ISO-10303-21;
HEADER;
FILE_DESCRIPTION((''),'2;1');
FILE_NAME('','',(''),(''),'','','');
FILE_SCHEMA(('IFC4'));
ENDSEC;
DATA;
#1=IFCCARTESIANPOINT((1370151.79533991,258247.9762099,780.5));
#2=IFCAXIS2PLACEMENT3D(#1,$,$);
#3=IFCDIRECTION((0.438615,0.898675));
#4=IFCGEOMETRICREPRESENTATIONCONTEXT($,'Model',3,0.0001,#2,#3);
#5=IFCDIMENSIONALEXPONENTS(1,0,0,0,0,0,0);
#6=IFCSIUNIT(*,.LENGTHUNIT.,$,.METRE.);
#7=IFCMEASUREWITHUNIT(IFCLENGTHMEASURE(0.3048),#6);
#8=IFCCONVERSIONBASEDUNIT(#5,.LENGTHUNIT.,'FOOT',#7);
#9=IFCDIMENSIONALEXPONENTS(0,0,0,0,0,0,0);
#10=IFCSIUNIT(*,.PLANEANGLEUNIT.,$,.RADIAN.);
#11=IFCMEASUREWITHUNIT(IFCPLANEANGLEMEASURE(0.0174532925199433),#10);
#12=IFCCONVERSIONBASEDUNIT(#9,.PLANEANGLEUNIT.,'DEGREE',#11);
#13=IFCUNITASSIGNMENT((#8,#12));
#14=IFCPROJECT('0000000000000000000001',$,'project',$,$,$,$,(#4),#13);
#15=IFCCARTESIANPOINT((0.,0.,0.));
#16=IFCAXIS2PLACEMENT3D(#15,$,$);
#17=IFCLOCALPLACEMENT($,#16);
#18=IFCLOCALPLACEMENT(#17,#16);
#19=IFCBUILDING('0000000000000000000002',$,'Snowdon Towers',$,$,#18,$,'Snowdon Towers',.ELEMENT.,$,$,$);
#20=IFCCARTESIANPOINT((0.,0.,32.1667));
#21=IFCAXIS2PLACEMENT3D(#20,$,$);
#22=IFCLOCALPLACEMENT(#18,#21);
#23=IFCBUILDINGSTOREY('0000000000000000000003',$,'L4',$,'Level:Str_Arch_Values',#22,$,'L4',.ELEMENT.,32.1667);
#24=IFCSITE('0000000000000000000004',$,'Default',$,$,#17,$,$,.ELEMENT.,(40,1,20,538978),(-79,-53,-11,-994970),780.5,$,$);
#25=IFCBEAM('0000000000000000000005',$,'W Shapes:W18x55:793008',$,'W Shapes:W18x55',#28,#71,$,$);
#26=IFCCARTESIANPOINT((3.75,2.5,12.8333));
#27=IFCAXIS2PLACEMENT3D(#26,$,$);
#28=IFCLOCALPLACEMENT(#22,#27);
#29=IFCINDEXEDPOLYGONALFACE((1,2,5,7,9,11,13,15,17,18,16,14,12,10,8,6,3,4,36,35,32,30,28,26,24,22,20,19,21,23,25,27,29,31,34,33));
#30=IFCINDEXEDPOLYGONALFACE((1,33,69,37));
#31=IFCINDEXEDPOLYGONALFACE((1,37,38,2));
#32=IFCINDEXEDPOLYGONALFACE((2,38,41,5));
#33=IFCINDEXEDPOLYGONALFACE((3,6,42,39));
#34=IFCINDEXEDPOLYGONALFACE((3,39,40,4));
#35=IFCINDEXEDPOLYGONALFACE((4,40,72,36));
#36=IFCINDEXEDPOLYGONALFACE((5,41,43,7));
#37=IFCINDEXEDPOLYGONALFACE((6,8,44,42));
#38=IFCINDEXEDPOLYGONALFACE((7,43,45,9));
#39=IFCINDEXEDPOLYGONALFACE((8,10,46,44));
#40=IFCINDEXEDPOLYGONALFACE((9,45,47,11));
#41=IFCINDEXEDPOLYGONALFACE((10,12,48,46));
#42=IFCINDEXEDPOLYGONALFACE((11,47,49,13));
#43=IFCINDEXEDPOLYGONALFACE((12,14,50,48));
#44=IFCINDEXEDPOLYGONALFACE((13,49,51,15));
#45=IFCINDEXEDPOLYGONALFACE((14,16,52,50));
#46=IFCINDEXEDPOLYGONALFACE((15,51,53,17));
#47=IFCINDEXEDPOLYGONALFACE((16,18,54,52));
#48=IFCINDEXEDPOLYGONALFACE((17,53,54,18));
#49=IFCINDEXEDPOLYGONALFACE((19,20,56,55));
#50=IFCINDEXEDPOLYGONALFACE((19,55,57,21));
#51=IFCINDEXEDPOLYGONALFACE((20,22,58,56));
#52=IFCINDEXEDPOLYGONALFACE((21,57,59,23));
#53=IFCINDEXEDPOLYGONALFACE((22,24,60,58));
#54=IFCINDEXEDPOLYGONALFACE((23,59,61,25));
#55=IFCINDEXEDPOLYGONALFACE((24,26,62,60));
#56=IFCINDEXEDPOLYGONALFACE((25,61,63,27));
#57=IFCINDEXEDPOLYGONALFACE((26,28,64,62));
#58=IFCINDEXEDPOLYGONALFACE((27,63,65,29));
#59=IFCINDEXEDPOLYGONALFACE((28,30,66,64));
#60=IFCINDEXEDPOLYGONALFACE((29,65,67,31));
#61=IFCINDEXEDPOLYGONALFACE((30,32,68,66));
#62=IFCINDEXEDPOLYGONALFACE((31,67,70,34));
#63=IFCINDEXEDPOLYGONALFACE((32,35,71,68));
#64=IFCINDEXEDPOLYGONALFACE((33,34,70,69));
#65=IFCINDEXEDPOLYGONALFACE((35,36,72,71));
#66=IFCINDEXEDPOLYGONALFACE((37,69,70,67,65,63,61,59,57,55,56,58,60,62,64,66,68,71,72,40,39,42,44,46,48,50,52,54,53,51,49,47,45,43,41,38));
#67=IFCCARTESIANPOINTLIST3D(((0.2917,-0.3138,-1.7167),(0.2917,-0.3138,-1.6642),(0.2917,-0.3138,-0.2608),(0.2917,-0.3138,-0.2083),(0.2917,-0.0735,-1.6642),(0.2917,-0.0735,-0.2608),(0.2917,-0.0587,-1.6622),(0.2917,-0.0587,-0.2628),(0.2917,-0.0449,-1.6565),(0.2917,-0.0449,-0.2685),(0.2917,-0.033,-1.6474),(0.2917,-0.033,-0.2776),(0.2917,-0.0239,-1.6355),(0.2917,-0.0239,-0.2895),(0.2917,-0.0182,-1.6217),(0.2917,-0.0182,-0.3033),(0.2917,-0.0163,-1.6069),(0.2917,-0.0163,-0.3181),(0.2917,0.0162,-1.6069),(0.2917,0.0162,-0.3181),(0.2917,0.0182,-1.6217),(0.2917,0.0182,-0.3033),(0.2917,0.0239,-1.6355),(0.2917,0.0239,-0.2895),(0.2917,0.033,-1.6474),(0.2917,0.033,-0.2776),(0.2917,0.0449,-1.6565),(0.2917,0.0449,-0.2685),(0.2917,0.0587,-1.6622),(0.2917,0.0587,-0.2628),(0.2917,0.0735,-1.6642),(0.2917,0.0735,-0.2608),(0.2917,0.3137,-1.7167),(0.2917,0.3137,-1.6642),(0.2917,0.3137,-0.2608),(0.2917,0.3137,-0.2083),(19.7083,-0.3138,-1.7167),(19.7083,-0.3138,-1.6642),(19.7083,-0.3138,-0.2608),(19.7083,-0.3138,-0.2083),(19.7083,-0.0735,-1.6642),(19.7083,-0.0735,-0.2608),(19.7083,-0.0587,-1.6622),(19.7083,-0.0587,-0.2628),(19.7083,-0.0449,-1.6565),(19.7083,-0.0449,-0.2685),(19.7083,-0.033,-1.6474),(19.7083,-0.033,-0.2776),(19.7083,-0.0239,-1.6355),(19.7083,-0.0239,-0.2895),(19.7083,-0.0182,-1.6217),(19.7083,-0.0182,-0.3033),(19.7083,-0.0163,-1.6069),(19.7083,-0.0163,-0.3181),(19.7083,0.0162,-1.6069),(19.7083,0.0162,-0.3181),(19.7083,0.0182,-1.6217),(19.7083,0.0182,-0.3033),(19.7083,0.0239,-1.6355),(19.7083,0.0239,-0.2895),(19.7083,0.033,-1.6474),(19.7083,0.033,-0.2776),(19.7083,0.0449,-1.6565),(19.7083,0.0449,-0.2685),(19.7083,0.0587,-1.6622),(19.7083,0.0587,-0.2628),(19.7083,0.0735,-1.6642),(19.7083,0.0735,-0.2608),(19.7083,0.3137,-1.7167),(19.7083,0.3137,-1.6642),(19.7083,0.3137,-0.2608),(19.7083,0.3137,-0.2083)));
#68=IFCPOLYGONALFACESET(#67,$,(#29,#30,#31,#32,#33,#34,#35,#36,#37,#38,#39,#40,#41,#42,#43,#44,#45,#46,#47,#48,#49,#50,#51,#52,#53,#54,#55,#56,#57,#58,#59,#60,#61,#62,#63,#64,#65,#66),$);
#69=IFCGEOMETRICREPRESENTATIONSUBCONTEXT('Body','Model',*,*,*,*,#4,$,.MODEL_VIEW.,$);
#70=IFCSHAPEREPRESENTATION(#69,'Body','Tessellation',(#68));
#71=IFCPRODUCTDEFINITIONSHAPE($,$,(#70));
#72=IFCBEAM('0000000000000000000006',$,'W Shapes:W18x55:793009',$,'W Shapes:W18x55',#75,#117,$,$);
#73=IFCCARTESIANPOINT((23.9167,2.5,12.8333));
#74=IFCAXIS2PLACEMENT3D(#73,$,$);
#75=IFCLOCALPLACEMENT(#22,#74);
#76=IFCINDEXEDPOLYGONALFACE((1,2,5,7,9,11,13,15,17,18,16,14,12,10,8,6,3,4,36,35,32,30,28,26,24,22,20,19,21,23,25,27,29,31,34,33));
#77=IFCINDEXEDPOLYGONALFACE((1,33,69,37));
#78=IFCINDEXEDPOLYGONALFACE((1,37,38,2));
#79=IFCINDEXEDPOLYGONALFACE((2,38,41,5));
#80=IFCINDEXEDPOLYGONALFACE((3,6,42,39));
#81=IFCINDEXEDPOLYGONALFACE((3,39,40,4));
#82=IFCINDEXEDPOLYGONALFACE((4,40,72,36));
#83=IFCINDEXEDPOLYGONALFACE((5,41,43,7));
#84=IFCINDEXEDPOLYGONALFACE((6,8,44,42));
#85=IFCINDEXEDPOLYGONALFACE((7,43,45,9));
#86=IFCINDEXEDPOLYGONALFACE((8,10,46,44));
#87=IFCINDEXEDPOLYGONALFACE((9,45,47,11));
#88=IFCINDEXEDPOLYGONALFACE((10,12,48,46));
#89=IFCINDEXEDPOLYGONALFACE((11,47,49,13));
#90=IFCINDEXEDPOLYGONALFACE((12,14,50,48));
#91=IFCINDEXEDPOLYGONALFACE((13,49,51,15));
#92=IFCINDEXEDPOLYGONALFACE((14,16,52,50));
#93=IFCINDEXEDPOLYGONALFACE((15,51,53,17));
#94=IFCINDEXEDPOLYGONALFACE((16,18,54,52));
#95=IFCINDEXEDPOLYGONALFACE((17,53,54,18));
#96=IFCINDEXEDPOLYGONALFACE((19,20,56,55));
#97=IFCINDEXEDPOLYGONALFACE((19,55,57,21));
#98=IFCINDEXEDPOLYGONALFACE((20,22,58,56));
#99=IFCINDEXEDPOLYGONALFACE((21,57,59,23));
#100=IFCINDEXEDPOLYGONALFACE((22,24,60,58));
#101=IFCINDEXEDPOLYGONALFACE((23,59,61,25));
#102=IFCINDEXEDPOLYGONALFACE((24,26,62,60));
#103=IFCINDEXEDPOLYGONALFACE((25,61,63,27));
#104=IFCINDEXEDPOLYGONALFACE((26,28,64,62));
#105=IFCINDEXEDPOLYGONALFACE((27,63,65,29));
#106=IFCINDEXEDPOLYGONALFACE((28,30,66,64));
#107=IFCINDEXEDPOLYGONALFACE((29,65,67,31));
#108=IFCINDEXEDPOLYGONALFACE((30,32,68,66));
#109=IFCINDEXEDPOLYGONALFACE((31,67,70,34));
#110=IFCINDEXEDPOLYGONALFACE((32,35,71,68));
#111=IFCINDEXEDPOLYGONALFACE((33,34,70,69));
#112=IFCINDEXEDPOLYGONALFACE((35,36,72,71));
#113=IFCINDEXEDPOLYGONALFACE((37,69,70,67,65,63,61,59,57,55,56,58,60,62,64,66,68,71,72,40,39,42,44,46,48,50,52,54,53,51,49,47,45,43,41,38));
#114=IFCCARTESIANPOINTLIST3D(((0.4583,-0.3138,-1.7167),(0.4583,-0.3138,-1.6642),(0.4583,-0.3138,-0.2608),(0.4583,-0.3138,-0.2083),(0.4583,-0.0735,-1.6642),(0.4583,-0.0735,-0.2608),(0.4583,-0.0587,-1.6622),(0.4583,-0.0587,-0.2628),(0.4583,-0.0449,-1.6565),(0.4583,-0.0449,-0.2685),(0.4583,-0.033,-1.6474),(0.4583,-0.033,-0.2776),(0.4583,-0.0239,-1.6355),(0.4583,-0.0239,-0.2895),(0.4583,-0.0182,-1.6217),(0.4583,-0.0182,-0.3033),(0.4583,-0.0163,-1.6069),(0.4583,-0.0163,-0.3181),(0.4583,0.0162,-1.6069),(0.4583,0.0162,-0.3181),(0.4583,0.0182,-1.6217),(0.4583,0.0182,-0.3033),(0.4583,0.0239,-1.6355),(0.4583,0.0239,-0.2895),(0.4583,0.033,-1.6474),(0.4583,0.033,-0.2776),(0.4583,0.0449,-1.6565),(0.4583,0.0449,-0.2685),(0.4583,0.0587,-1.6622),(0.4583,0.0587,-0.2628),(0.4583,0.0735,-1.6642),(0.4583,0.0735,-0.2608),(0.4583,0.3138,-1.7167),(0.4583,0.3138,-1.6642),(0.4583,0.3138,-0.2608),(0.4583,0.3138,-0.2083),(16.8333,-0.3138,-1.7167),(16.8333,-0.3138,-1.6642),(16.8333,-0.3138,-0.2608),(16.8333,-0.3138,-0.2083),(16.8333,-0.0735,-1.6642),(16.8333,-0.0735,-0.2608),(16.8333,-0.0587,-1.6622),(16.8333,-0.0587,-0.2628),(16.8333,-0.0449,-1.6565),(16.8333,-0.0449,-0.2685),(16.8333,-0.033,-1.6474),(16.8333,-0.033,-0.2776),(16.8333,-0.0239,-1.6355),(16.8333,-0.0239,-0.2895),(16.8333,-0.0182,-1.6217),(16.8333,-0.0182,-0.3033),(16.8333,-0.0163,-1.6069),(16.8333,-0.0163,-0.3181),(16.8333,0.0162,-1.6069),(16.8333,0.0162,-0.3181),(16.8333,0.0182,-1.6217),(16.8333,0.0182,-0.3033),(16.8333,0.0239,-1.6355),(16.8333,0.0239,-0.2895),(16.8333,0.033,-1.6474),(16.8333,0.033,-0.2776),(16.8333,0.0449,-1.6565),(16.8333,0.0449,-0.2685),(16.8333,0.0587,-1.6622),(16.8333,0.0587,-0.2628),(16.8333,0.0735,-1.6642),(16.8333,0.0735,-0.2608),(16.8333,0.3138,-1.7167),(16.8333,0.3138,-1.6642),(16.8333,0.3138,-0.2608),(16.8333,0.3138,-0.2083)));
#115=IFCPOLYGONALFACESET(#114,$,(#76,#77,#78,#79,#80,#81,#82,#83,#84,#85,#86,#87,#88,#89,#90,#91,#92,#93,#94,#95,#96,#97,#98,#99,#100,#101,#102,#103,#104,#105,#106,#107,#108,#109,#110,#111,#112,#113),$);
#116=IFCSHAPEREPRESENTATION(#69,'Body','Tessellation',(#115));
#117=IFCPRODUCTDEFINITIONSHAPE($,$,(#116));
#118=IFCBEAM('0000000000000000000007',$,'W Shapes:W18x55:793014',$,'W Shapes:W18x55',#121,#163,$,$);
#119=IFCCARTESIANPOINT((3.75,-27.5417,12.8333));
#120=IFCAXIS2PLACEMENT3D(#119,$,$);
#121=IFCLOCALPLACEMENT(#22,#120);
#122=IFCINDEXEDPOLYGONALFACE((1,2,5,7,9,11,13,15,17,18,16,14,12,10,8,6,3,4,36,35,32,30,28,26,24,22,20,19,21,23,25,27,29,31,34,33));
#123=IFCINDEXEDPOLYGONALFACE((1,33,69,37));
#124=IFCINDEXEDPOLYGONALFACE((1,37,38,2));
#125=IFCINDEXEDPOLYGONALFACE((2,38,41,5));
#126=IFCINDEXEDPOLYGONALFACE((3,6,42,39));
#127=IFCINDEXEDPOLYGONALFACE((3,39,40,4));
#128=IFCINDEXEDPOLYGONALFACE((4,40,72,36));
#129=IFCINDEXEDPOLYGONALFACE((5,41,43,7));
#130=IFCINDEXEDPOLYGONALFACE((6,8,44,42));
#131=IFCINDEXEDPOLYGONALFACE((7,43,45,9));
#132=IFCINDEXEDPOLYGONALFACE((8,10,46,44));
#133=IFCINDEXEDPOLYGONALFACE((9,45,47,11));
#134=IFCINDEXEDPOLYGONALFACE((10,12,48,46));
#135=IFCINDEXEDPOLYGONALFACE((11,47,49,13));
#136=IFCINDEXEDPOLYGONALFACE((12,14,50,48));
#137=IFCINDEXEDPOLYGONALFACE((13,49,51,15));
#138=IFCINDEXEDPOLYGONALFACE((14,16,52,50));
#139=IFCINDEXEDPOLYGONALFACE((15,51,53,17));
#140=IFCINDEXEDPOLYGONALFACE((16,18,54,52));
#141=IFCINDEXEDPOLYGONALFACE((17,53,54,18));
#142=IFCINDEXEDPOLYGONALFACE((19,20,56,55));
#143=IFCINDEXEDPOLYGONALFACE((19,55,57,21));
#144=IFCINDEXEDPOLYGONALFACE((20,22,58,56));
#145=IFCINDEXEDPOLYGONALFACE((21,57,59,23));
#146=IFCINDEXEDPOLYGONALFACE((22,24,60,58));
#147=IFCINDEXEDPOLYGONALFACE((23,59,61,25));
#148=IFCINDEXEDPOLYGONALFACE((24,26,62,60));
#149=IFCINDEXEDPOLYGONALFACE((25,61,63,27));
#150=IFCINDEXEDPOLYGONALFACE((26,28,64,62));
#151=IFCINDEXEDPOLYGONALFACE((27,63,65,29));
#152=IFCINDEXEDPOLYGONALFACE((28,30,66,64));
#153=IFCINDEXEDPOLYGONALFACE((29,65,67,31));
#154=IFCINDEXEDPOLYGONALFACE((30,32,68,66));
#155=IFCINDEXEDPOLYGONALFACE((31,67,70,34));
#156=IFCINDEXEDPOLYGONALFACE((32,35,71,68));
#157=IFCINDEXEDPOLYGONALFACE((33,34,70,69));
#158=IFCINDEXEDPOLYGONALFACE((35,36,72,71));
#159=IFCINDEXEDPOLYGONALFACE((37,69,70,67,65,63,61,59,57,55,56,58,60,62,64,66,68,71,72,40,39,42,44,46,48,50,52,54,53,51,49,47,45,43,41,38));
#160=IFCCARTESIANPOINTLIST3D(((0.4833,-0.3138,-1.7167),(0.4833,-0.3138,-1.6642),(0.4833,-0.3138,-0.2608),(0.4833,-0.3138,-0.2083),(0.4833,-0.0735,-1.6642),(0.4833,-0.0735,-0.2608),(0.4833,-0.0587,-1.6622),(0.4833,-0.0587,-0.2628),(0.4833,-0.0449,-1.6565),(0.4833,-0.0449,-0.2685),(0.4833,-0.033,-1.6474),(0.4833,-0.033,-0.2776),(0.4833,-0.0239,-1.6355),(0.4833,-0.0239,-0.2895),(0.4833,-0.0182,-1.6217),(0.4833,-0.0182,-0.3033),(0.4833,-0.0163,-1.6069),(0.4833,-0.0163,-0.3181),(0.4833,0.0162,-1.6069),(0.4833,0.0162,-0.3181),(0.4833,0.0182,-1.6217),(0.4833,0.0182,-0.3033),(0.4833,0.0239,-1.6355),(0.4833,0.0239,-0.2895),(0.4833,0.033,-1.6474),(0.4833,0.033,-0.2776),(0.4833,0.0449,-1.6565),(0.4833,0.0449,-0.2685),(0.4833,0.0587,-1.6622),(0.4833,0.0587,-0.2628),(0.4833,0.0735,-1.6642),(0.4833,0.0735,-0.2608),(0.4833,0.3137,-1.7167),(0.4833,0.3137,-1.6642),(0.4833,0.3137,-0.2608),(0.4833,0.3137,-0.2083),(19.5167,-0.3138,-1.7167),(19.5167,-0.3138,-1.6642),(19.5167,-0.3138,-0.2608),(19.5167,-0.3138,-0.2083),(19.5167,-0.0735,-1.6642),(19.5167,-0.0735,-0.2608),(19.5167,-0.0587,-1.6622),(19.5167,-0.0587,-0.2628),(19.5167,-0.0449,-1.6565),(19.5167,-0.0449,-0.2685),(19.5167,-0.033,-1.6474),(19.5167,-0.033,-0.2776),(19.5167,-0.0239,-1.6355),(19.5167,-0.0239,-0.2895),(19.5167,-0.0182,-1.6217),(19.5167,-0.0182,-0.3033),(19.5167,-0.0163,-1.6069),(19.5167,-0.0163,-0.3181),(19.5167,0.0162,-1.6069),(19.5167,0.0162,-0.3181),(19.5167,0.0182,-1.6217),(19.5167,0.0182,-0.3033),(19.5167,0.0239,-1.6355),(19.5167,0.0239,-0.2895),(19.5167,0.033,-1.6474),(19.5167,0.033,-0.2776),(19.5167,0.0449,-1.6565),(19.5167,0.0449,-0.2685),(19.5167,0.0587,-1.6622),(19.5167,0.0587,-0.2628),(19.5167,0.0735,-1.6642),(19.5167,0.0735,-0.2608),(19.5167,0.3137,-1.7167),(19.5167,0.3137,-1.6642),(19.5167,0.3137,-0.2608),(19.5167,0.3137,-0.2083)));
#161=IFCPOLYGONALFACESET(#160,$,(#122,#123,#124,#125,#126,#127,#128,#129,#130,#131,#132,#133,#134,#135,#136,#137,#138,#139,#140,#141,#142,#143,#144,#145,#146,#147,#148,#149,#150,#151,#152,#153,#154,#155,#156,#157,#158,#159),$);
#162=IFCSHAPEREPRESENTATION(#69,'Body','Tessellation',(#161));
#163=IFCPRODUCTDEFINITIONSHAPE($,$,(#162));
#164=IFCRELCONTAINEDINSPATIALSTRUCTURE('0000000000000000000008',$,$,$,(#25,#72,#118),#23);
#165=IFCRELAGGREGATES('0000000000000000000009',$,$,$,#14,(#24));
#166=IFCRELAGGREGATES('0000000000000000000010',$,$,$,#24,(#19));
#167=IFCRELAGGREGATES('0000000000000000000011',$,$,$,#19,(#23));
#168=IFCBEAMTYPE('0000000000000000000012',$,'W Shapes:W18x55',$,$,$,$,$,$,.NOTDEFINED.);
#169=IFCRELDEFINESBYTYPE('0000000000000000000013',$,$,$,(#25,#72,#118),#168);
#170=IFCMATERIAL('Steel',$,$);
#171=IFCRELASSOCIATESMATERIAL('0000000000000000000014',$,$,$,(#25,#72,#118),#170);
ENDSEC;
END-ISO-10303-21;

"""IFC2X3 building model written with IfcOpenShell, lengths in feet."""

from ifc_helpers import new_model, entity, si_unit, converted_unit, direction, frame, frame_2d, origin, place, context, subcontext, project, spatial, i_section, extrude, material, type_object, element, save


model = new_model("IFC2X3")

# Units and contexts
model_context = context("Model", 3, precision=0.0001, world=frame((1370151.79533991, 258247.9762099, 780.5)), true_north=direction((0.438615, 0.898675)))
body_context = subcontext(model_context, "Body", "Model", "MODEL_VIEW")
ifc_project = project(units=[converted_unit("LENGTHUNIT", "FOOT", entity("IfcLengthMeasure", 0.3048), si_unit("LENGTHUNIT", "METRE"), dimensions=[1, 0, 0, 0, 0, 0, 0]), converted_unit("PLANEANGLEUNIT", "DEGREE", entity("IfcPlaneAngleMeasure", 0.0174532925199433), si_unit("PLANEANGLEUNIT", "RADIAN"), dimensions=[0, 0, 0, 0, 0, 0, 0])], contexts=[model_context])

# Site, building, storey
site_placement = place(None, origin())
site = spatial("IfcSite", under=ifc_project, at=site_placement, Name="Default", CompositionType="ELEMENT", RefLatitude=(40, 1, 20, 538978), RefLongitude=(-79, -53, -11, -994970), RefElevation=780.5)
building_placement = place(site_placement, origin())
building = spatial("IfcBuilding", under=site, at=building_placement, Name="Snowdon Towers", LongName="Snowdon Towers", CompositionType="ELEMENT")
storey_placement = place(building_placement, frame((0.0, 0.0, 32.1667)))
storey = spatial("IfcBuildingStorey", under=building, at=storey_placement, Name="L4", ObjectType="Level:Str_Arch_Values", LongName="L4", CompositionType="ELEMENT", Elevation=32.1667)

# Beams
ifc_material = material(Name="Steel")
beam_type_1 = type_object("IfcBeamType", Name="W Shapes:W18x55", PredefinedType="NOTDEFINED")
beam_1_placement = place(storey_placement, frame((3.75, 2.5, 12.8333)))
element("IfcBeam", 1, at=beam_1_placement, inside=storey, type_object=beam_type_1, material=ifc_material, Name="W Shapes:W18x55:793008", ObjectType="W Shapes:W18x55", context=body_context, shape_type="SweptSolid", body=[
    extrude(i_section(OverallWidth=0.6275, OverallDepth=1.5083, WebThickness=0.0325, FlangeThickness=0.0525, FilletRadius=0.0573, at=frame_2d((0.0, 0.0), x_axis=(0.0, 1.0))), frame((0.2917, 0.0, -0.9625), z_axis=(1.0, 0.0, 0.0), x_axis=(0.0, 0.0, -1.0)), (0.0, 0.0, 1.0), 19.4167),
])
beam_2_placement = place(storey_placement, frame((23.9167, 2.5, 12.8333)))
element("IfcBeam", 2, at=beam_2_placement, inside=storey, type_object=beam_type_1, material=ifc_material, Name="W Shapes:W18x55:793009", ObjectType="W Shapes:W18x55", context=body_context, shape_type="SweptSolid", body=[
    extrude(i_section(OverallWidth=0.6275, OverallDepth=1.5083, WebThickness=0.0325, FlangeThickness=0.0525, FilletRadius=0.0573, at=frame_2d((0.0, 0.0), x_axis=(0.0, 1.0))), frame((0.4583, 0.0, -0.9625), z_axis=(1.0, 0.0, 0.0), x_axis=(0.0, 0.0, -1.0)), (0.0, 0.0, 1.0), 16.375),
])
beam_3_placement = place(storey_placement, frame((3.75, -27.5417, 12.8333)))
element("IfcBeam", 3, at=beam_3_placement, inside=storey, type_object=beam_type_1, material=ifc_material, Name="W Shapes:W18x55:793014", ObjectType="W Shapes:W18x55", context=body_context, shape_type="SweptSolid", body=[
    extrude(i_section(OverallWidth=0.6275, OverallDepth=1.5083, WebThickness=0.0325, FlangeThickness=0.0525, FilletRadius=0.0573, at=frame_2d((0.0, 0.0), x_axis=(0.0, 1.0))), frame((0.4833, 0.0, -0.9625), z_axis=(1.0, 0.0, 0.0), x_axis=(0.0, 0.0, -1.0)), (0.0, 0.0, 1.0), 19.0333),
])

save(model, "model.ifc")
